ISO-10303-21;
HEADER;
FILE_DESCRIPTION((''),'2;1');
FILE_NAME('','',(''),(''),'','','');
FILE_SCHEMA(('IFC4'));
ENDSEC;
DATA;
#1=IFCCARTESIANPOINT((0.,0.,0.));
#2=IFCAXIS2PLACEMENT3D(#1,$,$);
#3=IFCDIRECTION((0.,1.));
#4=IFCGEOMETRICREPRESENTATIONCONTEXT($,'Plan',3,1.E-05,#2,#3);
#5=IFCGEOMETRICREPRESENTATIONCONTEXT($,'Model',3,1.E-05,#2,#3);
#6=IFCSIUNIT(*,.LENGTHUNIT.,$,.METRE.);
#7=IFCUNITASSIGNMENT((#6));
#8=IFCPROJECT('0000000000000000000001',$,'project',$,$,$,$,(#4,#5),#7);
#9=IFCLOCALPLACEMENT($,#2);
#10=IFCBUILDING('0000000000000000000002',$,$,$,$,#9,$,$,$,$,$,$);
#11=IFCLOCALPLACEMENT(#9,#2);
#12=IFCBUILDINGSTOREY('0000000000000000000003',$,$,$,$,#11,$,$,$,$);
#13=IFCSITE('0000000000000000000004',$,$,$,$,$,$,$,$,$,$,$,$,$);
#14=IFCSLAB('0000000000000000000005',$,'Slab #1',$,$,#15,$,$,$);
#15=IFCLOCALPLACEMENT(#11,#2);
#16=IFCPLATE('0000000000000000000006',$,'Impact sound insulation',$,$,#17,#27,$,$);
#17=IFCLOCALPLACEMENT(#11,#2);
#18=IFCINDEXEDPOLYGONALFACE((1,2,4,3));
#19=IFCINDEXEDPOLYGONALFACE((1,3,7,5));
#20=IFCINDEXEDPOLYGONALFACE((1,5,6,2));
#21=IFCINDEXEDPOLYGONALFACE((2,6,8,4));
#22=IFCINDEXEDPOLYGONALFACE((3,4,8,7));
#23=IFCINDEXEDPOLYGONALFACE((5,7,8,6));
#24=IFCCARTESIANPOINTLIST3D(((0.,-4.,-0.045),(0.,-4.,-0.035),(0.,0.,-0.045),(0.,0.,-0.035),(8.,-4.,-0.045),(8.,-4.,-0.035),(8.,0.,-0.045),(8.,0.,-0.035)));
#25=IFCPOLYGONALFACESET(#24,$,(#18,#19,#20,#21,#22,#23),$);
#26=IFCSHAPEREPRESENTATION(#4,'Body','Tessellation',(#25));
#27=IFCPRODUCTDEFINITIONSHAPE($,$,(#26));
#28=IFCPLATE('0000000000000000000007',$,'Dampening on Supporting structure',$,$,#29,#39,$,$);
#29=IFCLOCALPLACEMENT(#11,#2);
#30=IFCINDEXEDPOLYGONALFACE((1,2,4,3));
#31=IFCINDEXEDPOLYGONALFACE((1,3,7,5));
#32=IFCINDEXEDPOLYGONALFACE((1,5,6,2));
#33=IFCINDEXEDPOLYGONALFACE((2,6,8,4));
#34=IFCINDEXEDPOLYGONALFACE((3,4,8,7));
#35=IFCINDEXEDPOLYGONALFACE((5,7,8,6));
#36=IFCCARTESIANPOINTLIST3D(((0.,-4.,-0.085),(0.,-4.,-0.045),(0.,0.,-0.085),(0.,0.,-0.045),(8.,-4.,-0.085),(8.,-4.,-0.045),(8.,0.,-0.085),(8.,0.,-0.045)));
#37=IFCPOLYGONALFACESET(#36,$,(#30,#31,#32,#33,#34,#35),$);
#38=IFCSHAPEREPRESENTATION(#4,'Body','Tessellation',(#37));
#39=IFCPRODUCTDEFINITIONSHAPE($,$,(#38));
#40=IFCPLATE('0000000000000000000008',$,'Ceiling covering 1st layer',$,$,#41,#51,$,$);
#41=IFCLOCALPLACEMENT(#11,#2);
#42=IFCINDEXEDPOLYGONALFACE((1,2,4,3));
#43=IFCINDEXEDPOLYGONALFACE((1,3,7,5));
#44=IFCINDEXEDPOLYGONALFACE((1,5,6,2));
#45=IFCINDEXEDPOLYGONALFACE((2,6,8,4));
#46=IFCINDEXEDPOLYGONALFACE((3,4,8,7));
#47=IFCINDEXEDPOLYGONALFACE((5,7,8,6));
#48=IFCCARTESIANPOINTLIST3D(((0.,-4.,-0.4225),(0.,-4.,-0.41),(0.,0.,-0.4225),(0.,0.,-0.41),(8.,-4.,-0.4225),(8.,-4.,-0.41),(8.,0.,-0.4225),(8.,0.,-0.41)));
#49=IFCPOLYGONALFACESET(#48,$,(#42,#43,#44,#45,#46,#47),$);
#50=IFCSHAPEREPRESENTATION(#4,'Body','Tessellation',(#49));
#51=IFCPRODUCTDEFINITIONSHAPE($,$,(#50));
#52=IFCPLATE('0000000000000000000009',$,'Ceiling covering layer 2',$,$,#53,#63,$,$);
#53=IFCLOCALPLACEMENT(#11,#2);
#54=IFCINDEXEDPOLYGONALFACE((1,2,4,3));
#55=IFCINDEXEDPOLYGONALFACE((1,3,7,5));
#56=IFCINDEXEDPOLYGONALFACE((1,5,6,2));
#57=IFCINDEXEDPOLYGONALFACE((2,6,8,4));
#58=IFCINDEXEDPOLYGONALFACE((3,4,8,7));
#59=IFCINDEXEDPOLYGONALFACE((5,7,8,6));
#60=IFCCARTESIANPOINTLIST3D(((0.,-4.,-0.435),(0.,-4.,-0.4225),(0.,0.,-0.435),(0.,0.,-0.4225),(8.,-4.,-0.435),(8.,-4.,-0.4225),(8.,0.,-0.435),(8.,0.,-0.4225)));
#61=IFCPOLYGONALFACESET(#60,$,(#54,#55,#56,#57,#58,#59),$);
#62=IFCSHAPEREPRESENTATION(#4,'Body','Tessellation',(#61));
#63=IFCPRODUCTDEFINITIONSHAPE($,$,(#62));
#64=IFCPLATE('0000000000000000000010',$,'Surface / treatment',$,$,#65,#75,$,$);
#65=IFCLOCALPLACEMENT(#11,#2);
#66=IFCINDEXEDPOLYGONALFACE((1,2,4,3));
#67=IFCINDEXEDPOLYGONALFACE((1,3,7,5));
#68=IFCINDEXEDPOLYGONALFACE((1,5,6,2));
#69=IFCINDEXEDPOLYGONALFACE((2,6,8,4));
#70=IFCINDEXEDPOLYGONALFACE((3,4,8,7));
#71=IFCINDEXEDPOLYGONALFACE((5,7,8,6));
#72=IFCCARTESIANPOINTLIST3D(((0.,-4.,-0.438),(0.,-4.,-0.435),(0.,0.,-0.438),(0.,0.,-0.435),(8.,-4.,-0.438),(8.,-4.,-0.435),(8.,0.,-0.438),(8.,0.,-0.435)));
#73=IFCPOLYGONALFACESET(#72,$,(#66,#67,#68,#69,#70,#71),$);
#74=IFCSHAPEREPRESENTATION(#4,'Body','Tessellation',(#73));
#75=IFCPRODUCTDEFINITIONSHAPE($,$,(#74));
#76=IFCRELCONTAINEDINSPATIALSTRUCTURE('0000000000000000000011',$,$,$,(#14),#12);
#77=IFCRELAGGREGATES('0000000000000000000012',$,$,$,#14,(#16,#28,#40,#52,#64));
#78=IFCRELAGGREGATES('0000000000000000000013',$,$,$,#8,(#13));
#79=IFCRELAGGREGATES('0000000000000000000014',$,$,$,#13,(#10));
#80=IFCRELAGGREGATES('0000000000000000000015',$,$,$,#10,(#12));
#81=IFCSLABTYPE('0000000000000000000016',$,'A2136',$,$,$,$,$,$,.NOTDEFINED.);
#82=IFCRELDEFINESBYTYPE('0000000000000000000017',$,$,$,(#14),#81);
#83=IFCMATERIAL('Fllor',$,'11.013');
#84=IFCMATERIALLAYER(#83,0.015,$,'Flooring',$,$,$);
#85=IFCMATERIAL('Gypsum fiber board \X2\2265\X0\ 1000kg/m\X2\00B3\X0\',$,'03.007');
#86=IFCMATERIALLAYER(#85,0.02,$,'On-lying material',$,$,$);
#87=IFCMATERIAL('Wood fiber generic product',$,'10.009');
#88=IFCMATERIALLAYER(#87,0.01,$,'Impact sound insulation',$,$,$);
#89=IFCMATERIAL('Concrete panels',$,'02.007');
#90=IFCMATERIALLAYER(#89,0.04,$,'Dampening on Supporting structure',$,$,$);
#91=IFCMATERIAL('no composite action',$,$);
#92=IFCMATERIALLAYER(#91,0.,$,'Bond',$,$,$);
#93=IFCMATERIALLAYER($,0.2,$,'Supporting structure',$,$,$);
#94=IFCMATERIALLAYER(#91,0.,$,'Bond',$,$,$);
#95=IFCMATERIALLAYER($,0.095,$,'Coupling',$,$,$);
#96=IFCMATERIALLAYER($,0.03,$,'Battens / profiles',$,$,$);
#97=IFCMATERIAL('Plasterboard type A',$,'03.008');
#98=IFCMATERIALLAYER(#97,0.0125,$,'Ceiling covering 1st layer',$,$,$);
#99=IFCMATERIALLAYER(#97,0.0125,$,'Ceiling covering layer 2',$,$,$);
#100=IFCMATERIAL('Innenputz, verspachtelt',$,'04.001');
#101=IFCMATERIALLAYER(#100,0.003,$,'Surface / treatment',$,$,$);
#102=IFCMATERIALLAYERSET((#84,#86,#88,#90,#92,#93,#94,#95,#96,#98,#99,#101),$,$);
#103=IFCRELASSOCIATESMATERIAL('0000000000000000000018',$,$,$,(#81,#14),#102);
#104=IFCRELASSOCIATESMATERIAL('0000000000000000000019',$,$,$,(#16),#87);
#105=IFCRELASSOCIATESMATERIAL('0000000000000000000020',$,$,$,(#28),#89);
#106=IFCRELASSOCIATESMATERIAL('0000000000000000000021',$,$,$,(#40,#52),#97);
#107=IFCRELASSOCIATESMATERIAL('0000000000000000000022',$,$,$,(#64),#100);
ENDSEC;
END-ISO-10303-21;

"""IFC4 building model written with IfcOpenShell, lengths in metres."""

from ifc_helpers import new_model, si_unit, direction, frame, frame_2d, origin, place, context, project, spatial, rectangle, extrude, material, layer, layer_set, type_object, element, aggregate, save


model = new_model("IFC4")

# Units and contexts
plan_context = context("Plan", 3, precision=1e-05, world=origin(), true_north=direction((0.0, 1.0)))
model_context = context("Model", 3, precision=1e-05, world=origin(), true_north=direction((0.0, 1.0)))
ifc_project = project(units=[si_unit("LENGTHUNIT", "METRE")], contexts=[plan_context, model_context])

# Site, building, storey
site = spatial("IfcSite", under=ifc_project)
building_placement = place(None, origin())
building = spatial("IfcBuilding", under=site, at=building_placement)
storey_placement = place(building_placement, origin())
storey = spatial("IfcBuildingStorey", under=building, at=storey_placement)

# Slab, plates
ifc_material_1 = material(Name="Fllor", Category="11.013")
ifc_layer_1 = layer(ifc_material_1, 0.015, Name="Flooring")
ifc_material_2 = material(Name="Gypsum fiber board ≥ 1000kg/m³", Category="03.007")
ifc_layer_2 = layer(ifc_material_2, 0.02, Name="On-lying material")
ifc_material_3 = material(Name="Wood fiber generic product", Category="10.009")
ifc_layer_3 = layer(ifc_material_3, 0.01, Name="Impact sound insulation")
ifc_material_4 = material(Name="Concrete panels", Category="02.007")
ifc_layer_4 = layer(ifc_material_4, 0.04, Name="Dampening on Supporting structure")
ifc_material_5 = material(Name="no composite action")
ifc_layer_5 = layer(ifc_material_5, 0.0, Name="Bond")
ifc_layer_6 = layer(None, 0.2, Name="Supporting structure")
ifc_layer_7 = layer(ifc_material_5, 0.0, Name="Bond")
ifc_layer_8 = layer(None, 0.095, Name="Coupling")
ifc_layer_9 = layer(None, 0.03, Name="Battens / profiles")
ifc_material_6 = material(Name="Plasterboard type A", Category="03.008")
ifc_layer_10 = layer(ifc_material_6, 0.0125, Name="Ceiling covering 1st layer")
ifc_layer_11 = layer(ifc_material_6, 0.0125, Name="Ceiling covering layer 2")
ifc_material_7 = material(Name="Innenputz, verspachtelt", Category="04.001")
ifc_layer_12 = layer(ifc_material_7, 0.003, Name="Surface / treatment")
ifc_layer_set = layer_set([ifc_layer_1, ifc_layer_2, ifc_layer_3, ifc_layer_4, ifc_layer_5, ifc_layer_6, ifc_layer_7, ifc_layer_8, ifc_layer_9, ifc_layer_10, ifc_layer_11, ifc_layer_12])
slab_type = type_object("IfcSlabType", Name="A2136", PredefinedType="NOTDEFINED", material=ifc_layer_set)
slab_placement = place(None, frame((0.0, 0.0, 0.0), z_axis=(0.0, 0.0, -1.0), x_axis=(1.0, 0.0, 0.0)))
slab = element("IfcSlab", 1, at=slab_placement, inside=storey, type_object=slab_type, material=ifc_layer_set, Name="Slab #1")
plate_1_placement = place(slab_placement, origin())
plate_1 = element("IfcPlate", 2, at=plate_1_placement, material=ifc_material_3, Name="Impact sound insulation", context=plan_context, shape_type="SweptSolid", body=[
    extrude(rectangle(XDim=8.0, YDim=4.0, at=frame_2d((4.0, 2.0), x_axis=(1.0, 0.0))), frame((0.0, 0.0, 0.035), z_axis=(0.0, 0.0, 1.0), x_axis=(1.0, 0.0, 0.0)), (0.0, 0.0, 1.0), 0.01),
])
plate_2_placement = place(slab_placement, origin())
plate_2 = element("IfcPlate", 3, at=plate_2_placement, material=ifc_material_4, Name="Dampening on Supporting structure", context=plan_context, shape_type="SweptSolid", body=[
    extrude(rectangle(XDim=8.0, YDim=4.0, at=frame_2d((4.0, 2.0), x_axis=(1.0, 0.0))), frame((0.0, 0.0, 0.045), z_axis=(0.0, 0.0, 1.0), x_axis=(1.0, 0.0, 0.0)), (0.0, 0.0, 1.0), 0.04),
])
plate_3_placement = place(slab_placement, origin())
plate_3 = element("IfcPlate", 4, at=plate_3_placement, material=ifc_material_6, Name="Ceiling covering 1st layer", context=plan_context, shape_type="SweptSolid", body=[
    extrude(rectangle(XDim=8.0, YDim=4.0, at=frame_2d((4.0, 2.0), x_axis=(1.0, 0.0))), frame((0.0, 0.0, 0.41), z_axis=(0.0, 0.0, 1.0), x_axis=(1.0, 0.0, 0.0)), (0.0, 0.0, 1.0), 0.0125),
])
plate_4_placement = place(slab_placement, origin())
plate_4 = element("IfcPlate", 5, at=plate_4_placement, material=ifc_material_6, Name="Ceiling covering layer 2", context=plan_context, shape_type="SweptSolid", body=[
    extrude(rectangle(XDim=8.0, YDim=4.0, at=frame_2d((4.0, 2.0), x_axis=(1.0, 0.0))), frame((0.0, 0.0, 0.4225), z_axis=(0.0, 0.0, 1.0), x_axis=(1.0, 0.0, 0.0)), (0.0, 0.0, 1.0), 0.0125),
])
plate_5_placement = place(slab_placement, origin())
plate_5 = element("IfcPlate", 6, at=plate_5_placement, material=ifc_material_7, Name="Surface / treatment", context=plan_context, shape_type="SweptSolid", body=[
    extrude(rectangle(XDim=8.0, YDim=4.0, at=frame_2d((4.0, 2.0), x_axis=(1.0, 0.0))), frame((0.0, 0.0, 0.435), z_axis=(0.0, 0.0, 1.0), x_axis=(1.0, 0.0, 0.0)), (0.0, 0.0, 1.0), 0.003),
])
aggregate(slab, [plate_1, plate_2, plate_3, plate_4, plate_5])

save(model, "model.ifc")
